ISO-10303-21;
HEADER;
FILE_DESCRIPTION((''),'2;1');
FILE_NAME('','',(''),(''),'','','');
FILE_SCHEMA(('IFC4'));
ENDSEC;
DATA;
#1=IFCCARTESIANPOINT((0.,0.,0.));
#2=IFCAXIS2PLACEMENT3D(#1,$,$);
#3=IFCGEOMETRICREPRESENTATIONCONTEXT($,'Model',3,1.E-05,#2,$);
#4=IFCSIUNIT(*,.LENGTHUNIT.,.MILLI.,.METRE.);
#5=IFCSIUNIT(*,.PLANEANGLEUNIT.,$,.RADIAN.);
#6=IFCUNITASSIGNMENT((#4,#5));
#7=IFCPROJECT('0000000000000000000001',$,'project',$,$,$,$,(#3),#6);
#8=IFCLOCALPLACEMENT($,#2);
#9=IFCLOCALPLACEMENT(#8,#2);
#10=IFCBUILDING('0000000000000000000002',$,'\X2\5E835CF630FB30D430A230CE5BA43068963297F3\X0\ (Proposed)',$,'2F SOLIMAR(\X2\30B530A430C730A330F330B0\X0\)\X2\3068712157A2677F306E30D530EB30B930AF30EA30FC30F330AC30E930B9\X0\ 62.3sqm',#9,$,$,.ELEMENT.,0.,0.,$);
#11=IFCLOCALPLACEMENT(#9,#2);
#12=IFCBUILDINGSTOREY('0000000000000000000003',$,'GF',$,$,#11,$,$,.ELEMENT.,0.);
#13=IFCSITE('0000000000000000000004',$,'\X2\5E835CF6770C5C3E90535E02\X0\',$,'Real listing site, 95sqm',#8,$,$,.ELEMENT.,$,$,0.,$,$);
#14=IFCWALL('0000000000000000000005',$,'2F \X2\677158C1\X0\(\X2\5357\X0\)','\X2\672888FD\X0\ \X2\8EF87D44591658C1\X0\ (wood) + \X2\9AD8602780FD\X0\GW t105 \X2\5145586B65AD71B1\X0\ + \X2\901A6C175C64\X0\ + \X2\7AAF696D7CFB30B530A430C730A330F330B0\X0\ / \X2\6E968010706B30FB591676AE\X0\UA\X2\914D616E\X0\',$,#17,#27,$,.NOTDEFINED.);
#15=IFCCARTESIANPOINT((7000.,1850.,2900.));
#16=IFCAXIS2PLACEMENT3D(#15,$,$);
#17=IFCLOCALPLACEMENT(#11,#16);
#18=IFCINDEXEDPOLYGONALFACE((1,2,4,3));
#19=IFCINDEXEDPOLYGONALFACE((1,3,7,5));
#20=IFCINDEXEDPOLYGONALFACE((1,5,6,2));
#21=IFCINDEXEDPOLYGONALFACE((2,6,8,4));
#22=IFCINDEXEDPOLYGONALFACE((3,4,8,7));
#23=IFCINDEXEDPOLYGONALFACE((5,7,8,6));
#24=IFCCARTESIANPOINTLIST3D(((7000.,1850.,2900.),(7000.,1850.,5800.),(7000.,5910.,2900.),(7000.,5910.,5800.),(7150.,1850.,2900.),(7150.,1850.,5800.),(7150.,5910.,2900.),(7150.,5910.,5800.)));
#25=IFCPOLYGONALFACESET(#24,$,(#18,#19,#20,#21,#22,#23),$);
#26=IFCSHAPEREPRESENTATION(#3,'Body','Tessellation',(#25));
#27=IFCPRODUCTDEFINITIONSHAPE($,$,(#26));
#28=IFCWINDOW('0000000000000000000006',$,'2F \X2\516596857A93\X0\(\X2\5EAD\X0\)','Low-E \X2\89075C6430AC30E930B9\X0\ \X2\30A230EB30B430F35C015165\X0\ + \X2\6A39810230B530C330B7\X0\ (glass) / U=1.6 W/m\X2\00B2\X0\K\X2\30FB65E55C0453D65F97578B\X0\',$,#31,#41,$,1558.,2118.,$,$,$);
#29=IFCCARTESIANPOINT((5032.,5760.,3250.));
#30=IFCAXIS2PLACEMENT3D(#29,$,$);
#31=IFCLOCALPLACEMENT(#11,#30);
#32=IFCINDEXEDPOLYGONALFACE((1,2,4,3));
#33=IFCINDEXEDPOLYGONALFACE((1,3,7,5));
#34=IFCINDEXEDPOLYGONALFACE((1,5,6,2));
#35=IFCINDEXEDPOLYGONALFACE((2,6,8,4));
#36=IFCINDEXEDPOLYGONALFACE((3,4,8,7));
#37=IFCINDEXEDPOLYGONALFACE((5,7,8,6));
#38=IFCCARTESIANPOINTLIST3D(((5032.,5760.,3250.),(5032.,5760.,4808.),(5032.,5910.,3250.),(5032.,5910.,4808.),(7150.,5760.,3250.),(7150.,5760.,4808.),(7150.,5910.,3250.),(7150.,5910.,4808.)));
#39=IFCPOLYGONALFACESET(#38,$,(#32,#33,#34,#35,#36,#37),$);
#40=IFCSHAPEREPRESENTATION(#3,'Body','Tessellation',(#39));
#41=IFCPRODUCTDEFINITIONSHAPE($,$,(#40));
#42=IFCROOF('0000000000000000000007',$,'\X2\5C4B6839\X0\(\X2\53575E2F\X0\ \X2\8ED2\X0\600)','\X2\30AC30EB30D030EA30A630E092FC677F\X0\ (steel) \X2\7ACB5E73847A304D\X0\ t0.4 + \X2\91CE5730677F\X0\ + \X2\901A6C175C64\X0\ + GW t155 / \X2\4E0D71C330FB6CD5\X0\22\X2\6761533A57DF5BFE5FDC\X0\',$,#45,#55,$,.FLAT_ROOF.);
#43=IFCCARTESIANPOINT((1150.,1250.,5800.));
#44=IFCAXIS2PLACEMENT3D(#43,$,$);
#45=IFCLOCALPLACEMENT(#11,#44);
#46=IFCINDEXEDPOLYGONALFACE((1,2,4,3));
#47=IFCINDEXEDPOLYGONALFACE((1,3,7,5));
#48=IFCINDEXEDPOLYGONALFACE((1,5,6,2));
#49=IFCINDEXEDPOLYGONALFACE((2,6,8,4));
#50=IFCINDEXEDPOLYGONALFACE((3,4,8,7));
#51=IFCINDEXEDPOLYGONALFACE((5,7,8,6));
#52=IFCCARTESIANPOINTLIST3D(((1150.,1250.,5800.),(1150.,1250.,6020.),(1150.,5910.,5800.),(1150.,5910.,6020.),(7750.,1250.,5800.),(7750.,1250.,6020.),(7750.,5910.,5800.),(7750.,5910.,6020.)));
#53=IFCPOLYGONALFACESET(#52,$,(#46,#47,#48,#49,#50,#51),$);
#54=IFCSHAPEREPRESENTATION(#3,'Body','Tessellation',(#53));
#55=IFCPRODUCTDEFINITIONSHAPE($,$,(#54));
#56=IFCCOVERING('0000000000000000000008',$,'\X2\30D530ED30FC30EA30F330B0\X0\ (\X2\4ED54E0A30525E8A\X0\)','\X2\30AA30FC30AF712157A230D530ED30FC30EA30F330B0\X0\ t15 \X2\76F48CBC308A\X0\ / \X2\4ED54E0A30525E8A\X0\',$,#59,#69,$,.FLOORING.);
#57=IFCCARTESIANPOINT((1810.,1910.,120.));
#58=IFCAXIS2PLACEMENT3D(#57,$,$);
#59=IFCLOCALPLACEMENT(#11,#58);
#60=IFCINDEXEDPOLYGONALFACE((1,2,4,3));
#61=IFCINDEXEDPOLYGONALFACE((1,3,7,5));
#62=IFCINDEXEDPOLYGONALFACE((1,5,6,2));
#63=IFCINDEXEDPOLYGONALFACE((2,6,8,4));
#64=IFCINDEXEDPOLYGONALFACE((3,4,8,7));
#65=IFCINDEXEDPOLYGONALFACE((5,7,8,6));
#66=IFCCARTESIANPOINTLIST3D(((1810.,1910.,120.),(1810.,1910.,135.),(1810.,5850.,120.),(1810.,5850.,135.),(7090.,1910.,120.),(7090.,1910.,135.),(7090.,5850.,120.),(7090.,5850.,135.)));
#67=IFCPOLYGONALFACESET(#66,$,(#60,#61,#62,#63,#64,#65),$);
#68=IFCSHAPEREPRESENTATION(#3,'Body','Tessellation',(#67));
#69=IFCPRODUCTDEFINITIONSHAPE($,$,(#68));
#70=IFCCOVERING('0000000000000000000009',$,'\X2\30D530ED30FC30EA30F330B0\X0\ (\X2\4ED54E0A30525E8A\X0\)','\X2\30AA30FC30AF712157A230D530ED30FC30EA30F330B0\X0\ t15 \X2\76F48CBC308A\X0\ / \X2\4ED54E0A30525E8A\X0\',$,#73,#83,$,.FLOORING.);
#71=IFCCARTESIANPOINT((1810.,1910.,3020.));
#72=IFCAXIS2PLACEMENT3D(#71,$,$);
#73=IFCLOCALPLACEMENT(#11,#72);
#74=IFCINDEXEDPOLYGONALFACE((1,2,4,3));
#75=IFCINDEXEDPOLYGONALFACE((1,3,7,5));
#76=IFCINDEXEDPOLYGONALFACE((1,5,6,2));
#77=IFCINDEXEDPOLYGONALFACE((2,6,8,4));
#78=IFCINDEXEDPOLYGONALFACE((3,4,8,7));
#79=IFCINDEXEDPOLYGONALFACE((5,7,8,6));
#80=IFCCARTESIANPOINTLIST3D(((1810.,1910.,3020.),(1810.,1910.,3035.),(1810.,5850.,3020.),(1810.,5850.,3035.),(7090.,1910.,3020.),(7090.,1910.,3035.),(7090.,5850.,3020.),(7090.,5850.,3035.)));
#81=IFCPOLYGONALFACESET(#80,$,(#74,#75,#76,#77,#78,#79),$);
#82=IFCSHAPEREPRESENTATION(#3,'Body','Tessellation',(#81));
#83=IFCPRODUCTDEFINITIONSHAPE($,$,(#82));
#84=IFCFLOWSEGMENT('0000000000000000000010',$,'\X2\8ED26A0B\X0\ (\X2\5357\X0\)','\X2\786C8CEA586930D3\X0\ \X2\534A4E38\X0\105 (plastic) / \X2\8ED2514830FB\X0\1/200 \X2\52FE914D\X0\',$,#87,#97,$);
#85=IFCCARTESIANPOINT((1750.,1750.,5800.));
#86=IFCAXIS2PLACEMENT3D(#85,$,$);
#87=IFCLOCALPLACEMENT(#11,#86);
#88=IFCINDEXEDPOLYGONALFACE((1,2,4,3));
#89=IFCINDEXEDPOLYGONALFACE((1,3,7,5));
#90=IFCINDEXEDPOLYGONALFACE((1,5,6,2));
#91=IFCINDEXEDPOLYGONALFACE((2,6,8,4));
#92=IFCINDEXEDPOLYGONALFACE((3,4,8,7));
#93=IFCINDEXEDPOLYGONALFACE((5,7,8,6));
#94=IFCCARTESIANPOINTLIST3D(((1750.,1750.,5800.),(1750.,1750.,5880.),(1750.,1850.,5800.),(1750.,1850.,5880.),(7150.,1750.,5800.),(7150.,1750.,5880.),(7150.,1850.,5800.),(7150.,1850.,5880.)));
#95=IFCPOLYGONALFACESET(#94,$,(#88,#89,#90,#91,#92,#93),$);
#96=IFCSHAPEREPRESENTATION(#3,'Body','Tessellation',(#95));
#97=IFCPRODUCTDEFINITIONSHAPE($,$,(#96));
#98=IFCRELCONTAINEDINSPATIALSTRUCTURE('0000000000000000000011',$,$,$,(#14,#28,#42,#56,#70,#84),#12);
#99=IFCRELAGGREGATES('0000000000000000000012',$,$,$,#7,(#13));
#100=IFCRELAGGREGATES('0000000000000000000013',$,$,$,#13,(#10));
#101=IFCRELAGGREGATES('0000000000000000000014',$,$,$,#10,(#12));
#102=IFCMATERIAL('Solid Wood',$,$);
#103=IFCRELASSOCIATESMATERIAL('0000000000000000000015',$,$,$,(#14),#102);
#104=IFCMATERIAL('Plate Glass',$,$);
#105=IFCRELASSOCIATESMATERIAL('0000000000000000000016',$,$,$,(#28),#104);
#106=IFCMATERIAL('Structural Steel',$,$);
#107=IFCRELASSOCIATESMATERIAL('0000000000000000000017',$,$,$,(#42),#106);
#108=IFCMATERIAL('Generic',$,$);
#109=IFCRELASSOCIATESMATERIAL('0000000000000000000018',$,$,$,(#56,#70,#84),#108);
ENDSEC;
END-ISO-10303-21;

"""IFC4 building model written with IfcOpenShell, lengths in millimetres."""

from ifc_helpers import new_model, si_unit, frame, frame_2d, origin, place, context, project, spatial, rectangle, extrude, material, element, fill, save


model = new_model("IFC4")

# Units and contexts
model_context = context("Model", 3, precision=1e-05, world=origin())
ifc_project = project(units=[si_unit("LENGTHUNIT", "METRE", prefix="MILLI"), si_unit("PLANEANGLEUNIT", "RADIAN")], contexts=[model_context])

# Site, building, storey
site_placement = place(None, origin())
site = spatial("IfcSite", under=ifc_project, at=site_placement, Name="広島県尾道市", ObjectType="Real listing site, 95sqm", CompositionType="ELEMENT", RefElevation=0.0)
building_placement = place(site_placement, origin())
building = spatial("IfcBuilding", under=site, at=building_placement, Name="広島・ピアノ室と防音 (Proposed)", ObjectType="2F SOLIMAR(サイディング)と無垢板のフルスクリーンガラス 62.3sqm", CompositionType="ELEMENT", ElevationOfRefHeight=0.0, ElevationOfTerrain=0.0)
storey_placement = place(building_placement, origin())
storey = spatial("IfcBuildingStorey", under=building, at=storey_placement, Name="GF", CompositionType="ELEMENT", Elevation=0.0)

# Shared definitions
ifc_material_1 = material(Name="Solid Wood")

# Wall, opening, window
ifc_material_2 = material(Name="Plate Glass")
wall_1_placement = place(storey_placement, frame((7000.0, 1850.0, 2900.0)))
wall_1 = element("IfcWall", 1, at=wall_1_placement, inside=storey, material=ifc_material_1, Name="2F 東壁(南)", Description="木製 軸組外壁 (wood) + 高性能GW t105 充填断熱 + 通気層 + 窯業系サイディング / 準耐火・外皮UA配慮", PredefinedType="NOTDEFINED", context=model_context, shape_type="SweptSolid", body=[
    extrude(rectangle(XDim=150.0, YDim=4060.0, at=frame_2d((75.0, 2030.0))), frame((7000.0, 1850.0, 2900.0)), (0.0, 0.0, 1.0), 2900.0),
])
opening_1_placement = place(storey_placement, frame((5032.0, 5760.0, 3250.0)))
opening_1 = element("IfcOpeningElement", 2, at=opening_1_placement, cuts=wall_1, PredefinedType="NOTDEFINED", context=model_context, shape_type="SweptSolid", body=[
    extrude(rectangle(XDim=2118.0, YDim=150.0, at=frame_2d((1059.0, 75.0))), frame((5032.0, 5760.0, 3250.0)), (0.0, 0.0, 1.0), 1558.0),
])
window_1_placement = place(storey_placement, frame((5032.0, 5760.0, 3250.0)))
window_1 = element("IfcWindow", 3, at=window_1_placement, inside=storey, material=ifc_material_2, Name="2F 入隅窓(庭)", Description="Low-E 複層ガラス アルゴン封入 + 樹脂サッシ (glass) / U=1.6 W/m²K・日射取得型", OverallHeight=1558.0, OverallWidth=2118.0, context=model_context, shape_type="SweptSolid", body=[
    extrude(rectangle(XDim=2118.0, YDim=150.0, at=frame_2d((1059.0, 75.0))), frame((5032.0, 5760.0, 3250.0)), (0.0, 0.0, 1.0), 1558.0),
])
fill(opening_1, window_1)

# Roof
ifc_material_3 = material(Name="Structural Steel")
for number, where, name in (
    (4, (1150.0, 1250.0, 5800.0), "屋根(南帯 軒600)"),
):
    element("IfcRoof", number, at=place(storey_placement, frame(where)), inside=storey, material=ifc_material_3, Name=name, Description="ガルバリウム鋼板 (steel) 立平葺き t0.4 + 野地板 + 通気層 + GW t155 / 不燃・法22条区域対応", PredefinedType="FLAT_ROOF", context=model_context, shape_type="SweptSolid", body=[
        extrude(rectangle(XDim=6600.0, YDim=4660.0, at=frame_2d((3300.0, 2330.0))), frame((1150.0, 1250.0, 5800.0)), (0.0, 0.0, 1.0), 220.0),
    ])

# Coverings
ifc_material_4 = material(Name="Generic")
covering_1_placement = place(storey_placement, frame((1810.0, 1910.0, 120.0)))
element("IfcCovering", 5, at=covering_1_placement, inside=storey, material=ifc_material_4, Name="フローリング (仕上げ床)", Description="オーク無垢フローリング t15 直貼り / 仕上げ床", PredefinedType="FLOORING", context=model_context, shape_type="SweptSolid", body=[
    extrude(rectangle(XDim=5280.0, YDim=3940.0, at=frame_2d((2640.0, 1970.0))), frame((1810.0, 1910.0, 120.0)), (0.0, 0.0, 1.0), 15.0),
])
covering_2_placement = place(storey_placement, frame((1810.0, 1910.0, 3020.0)))
element("IfcCovering", 6, at=covering_2_placement, inside=storey, material=ifc_material_4, Name="フローリング (仕上げ床)", Description="オーク無垢フローリング t15 直貼り / 仕上げ床", PredefinedType="FLOORING", context=model_context, shape_type="SweptSolid", body=[
    extrude(rectangle(XDim=5280.0, YDim=3940.0, at=frame_2d((2640.0, 1970.0))), frame((1810.0, 1910.0, 3020.0)), (0.0, 0.0, 1.0), 15.0),
])

# Flow segment
flow_segment_placement = place(storey_placement, frame((1750.0, 1750.0, 5800.0)))
element("IfcFlowSegment", 7, at=flow_segment_placement, inside=storey, material=ifc_material_4, Name="軒樋 (南)", Description="硬質塩ビ 半丸105 (plastic) / 軒先・1/200 勾配", context=model_context, shape_type="SweptSolid", body=[
    extrude(rectangle(XDim=5400.0, YDim=100.0, at=frame_2d((2700.0, 50.0))), frame((1750.0, 1750.0, 5800.0)), (0.0, 0.0, 1.0), 80.0),
])

save(model, "model.ifc")
